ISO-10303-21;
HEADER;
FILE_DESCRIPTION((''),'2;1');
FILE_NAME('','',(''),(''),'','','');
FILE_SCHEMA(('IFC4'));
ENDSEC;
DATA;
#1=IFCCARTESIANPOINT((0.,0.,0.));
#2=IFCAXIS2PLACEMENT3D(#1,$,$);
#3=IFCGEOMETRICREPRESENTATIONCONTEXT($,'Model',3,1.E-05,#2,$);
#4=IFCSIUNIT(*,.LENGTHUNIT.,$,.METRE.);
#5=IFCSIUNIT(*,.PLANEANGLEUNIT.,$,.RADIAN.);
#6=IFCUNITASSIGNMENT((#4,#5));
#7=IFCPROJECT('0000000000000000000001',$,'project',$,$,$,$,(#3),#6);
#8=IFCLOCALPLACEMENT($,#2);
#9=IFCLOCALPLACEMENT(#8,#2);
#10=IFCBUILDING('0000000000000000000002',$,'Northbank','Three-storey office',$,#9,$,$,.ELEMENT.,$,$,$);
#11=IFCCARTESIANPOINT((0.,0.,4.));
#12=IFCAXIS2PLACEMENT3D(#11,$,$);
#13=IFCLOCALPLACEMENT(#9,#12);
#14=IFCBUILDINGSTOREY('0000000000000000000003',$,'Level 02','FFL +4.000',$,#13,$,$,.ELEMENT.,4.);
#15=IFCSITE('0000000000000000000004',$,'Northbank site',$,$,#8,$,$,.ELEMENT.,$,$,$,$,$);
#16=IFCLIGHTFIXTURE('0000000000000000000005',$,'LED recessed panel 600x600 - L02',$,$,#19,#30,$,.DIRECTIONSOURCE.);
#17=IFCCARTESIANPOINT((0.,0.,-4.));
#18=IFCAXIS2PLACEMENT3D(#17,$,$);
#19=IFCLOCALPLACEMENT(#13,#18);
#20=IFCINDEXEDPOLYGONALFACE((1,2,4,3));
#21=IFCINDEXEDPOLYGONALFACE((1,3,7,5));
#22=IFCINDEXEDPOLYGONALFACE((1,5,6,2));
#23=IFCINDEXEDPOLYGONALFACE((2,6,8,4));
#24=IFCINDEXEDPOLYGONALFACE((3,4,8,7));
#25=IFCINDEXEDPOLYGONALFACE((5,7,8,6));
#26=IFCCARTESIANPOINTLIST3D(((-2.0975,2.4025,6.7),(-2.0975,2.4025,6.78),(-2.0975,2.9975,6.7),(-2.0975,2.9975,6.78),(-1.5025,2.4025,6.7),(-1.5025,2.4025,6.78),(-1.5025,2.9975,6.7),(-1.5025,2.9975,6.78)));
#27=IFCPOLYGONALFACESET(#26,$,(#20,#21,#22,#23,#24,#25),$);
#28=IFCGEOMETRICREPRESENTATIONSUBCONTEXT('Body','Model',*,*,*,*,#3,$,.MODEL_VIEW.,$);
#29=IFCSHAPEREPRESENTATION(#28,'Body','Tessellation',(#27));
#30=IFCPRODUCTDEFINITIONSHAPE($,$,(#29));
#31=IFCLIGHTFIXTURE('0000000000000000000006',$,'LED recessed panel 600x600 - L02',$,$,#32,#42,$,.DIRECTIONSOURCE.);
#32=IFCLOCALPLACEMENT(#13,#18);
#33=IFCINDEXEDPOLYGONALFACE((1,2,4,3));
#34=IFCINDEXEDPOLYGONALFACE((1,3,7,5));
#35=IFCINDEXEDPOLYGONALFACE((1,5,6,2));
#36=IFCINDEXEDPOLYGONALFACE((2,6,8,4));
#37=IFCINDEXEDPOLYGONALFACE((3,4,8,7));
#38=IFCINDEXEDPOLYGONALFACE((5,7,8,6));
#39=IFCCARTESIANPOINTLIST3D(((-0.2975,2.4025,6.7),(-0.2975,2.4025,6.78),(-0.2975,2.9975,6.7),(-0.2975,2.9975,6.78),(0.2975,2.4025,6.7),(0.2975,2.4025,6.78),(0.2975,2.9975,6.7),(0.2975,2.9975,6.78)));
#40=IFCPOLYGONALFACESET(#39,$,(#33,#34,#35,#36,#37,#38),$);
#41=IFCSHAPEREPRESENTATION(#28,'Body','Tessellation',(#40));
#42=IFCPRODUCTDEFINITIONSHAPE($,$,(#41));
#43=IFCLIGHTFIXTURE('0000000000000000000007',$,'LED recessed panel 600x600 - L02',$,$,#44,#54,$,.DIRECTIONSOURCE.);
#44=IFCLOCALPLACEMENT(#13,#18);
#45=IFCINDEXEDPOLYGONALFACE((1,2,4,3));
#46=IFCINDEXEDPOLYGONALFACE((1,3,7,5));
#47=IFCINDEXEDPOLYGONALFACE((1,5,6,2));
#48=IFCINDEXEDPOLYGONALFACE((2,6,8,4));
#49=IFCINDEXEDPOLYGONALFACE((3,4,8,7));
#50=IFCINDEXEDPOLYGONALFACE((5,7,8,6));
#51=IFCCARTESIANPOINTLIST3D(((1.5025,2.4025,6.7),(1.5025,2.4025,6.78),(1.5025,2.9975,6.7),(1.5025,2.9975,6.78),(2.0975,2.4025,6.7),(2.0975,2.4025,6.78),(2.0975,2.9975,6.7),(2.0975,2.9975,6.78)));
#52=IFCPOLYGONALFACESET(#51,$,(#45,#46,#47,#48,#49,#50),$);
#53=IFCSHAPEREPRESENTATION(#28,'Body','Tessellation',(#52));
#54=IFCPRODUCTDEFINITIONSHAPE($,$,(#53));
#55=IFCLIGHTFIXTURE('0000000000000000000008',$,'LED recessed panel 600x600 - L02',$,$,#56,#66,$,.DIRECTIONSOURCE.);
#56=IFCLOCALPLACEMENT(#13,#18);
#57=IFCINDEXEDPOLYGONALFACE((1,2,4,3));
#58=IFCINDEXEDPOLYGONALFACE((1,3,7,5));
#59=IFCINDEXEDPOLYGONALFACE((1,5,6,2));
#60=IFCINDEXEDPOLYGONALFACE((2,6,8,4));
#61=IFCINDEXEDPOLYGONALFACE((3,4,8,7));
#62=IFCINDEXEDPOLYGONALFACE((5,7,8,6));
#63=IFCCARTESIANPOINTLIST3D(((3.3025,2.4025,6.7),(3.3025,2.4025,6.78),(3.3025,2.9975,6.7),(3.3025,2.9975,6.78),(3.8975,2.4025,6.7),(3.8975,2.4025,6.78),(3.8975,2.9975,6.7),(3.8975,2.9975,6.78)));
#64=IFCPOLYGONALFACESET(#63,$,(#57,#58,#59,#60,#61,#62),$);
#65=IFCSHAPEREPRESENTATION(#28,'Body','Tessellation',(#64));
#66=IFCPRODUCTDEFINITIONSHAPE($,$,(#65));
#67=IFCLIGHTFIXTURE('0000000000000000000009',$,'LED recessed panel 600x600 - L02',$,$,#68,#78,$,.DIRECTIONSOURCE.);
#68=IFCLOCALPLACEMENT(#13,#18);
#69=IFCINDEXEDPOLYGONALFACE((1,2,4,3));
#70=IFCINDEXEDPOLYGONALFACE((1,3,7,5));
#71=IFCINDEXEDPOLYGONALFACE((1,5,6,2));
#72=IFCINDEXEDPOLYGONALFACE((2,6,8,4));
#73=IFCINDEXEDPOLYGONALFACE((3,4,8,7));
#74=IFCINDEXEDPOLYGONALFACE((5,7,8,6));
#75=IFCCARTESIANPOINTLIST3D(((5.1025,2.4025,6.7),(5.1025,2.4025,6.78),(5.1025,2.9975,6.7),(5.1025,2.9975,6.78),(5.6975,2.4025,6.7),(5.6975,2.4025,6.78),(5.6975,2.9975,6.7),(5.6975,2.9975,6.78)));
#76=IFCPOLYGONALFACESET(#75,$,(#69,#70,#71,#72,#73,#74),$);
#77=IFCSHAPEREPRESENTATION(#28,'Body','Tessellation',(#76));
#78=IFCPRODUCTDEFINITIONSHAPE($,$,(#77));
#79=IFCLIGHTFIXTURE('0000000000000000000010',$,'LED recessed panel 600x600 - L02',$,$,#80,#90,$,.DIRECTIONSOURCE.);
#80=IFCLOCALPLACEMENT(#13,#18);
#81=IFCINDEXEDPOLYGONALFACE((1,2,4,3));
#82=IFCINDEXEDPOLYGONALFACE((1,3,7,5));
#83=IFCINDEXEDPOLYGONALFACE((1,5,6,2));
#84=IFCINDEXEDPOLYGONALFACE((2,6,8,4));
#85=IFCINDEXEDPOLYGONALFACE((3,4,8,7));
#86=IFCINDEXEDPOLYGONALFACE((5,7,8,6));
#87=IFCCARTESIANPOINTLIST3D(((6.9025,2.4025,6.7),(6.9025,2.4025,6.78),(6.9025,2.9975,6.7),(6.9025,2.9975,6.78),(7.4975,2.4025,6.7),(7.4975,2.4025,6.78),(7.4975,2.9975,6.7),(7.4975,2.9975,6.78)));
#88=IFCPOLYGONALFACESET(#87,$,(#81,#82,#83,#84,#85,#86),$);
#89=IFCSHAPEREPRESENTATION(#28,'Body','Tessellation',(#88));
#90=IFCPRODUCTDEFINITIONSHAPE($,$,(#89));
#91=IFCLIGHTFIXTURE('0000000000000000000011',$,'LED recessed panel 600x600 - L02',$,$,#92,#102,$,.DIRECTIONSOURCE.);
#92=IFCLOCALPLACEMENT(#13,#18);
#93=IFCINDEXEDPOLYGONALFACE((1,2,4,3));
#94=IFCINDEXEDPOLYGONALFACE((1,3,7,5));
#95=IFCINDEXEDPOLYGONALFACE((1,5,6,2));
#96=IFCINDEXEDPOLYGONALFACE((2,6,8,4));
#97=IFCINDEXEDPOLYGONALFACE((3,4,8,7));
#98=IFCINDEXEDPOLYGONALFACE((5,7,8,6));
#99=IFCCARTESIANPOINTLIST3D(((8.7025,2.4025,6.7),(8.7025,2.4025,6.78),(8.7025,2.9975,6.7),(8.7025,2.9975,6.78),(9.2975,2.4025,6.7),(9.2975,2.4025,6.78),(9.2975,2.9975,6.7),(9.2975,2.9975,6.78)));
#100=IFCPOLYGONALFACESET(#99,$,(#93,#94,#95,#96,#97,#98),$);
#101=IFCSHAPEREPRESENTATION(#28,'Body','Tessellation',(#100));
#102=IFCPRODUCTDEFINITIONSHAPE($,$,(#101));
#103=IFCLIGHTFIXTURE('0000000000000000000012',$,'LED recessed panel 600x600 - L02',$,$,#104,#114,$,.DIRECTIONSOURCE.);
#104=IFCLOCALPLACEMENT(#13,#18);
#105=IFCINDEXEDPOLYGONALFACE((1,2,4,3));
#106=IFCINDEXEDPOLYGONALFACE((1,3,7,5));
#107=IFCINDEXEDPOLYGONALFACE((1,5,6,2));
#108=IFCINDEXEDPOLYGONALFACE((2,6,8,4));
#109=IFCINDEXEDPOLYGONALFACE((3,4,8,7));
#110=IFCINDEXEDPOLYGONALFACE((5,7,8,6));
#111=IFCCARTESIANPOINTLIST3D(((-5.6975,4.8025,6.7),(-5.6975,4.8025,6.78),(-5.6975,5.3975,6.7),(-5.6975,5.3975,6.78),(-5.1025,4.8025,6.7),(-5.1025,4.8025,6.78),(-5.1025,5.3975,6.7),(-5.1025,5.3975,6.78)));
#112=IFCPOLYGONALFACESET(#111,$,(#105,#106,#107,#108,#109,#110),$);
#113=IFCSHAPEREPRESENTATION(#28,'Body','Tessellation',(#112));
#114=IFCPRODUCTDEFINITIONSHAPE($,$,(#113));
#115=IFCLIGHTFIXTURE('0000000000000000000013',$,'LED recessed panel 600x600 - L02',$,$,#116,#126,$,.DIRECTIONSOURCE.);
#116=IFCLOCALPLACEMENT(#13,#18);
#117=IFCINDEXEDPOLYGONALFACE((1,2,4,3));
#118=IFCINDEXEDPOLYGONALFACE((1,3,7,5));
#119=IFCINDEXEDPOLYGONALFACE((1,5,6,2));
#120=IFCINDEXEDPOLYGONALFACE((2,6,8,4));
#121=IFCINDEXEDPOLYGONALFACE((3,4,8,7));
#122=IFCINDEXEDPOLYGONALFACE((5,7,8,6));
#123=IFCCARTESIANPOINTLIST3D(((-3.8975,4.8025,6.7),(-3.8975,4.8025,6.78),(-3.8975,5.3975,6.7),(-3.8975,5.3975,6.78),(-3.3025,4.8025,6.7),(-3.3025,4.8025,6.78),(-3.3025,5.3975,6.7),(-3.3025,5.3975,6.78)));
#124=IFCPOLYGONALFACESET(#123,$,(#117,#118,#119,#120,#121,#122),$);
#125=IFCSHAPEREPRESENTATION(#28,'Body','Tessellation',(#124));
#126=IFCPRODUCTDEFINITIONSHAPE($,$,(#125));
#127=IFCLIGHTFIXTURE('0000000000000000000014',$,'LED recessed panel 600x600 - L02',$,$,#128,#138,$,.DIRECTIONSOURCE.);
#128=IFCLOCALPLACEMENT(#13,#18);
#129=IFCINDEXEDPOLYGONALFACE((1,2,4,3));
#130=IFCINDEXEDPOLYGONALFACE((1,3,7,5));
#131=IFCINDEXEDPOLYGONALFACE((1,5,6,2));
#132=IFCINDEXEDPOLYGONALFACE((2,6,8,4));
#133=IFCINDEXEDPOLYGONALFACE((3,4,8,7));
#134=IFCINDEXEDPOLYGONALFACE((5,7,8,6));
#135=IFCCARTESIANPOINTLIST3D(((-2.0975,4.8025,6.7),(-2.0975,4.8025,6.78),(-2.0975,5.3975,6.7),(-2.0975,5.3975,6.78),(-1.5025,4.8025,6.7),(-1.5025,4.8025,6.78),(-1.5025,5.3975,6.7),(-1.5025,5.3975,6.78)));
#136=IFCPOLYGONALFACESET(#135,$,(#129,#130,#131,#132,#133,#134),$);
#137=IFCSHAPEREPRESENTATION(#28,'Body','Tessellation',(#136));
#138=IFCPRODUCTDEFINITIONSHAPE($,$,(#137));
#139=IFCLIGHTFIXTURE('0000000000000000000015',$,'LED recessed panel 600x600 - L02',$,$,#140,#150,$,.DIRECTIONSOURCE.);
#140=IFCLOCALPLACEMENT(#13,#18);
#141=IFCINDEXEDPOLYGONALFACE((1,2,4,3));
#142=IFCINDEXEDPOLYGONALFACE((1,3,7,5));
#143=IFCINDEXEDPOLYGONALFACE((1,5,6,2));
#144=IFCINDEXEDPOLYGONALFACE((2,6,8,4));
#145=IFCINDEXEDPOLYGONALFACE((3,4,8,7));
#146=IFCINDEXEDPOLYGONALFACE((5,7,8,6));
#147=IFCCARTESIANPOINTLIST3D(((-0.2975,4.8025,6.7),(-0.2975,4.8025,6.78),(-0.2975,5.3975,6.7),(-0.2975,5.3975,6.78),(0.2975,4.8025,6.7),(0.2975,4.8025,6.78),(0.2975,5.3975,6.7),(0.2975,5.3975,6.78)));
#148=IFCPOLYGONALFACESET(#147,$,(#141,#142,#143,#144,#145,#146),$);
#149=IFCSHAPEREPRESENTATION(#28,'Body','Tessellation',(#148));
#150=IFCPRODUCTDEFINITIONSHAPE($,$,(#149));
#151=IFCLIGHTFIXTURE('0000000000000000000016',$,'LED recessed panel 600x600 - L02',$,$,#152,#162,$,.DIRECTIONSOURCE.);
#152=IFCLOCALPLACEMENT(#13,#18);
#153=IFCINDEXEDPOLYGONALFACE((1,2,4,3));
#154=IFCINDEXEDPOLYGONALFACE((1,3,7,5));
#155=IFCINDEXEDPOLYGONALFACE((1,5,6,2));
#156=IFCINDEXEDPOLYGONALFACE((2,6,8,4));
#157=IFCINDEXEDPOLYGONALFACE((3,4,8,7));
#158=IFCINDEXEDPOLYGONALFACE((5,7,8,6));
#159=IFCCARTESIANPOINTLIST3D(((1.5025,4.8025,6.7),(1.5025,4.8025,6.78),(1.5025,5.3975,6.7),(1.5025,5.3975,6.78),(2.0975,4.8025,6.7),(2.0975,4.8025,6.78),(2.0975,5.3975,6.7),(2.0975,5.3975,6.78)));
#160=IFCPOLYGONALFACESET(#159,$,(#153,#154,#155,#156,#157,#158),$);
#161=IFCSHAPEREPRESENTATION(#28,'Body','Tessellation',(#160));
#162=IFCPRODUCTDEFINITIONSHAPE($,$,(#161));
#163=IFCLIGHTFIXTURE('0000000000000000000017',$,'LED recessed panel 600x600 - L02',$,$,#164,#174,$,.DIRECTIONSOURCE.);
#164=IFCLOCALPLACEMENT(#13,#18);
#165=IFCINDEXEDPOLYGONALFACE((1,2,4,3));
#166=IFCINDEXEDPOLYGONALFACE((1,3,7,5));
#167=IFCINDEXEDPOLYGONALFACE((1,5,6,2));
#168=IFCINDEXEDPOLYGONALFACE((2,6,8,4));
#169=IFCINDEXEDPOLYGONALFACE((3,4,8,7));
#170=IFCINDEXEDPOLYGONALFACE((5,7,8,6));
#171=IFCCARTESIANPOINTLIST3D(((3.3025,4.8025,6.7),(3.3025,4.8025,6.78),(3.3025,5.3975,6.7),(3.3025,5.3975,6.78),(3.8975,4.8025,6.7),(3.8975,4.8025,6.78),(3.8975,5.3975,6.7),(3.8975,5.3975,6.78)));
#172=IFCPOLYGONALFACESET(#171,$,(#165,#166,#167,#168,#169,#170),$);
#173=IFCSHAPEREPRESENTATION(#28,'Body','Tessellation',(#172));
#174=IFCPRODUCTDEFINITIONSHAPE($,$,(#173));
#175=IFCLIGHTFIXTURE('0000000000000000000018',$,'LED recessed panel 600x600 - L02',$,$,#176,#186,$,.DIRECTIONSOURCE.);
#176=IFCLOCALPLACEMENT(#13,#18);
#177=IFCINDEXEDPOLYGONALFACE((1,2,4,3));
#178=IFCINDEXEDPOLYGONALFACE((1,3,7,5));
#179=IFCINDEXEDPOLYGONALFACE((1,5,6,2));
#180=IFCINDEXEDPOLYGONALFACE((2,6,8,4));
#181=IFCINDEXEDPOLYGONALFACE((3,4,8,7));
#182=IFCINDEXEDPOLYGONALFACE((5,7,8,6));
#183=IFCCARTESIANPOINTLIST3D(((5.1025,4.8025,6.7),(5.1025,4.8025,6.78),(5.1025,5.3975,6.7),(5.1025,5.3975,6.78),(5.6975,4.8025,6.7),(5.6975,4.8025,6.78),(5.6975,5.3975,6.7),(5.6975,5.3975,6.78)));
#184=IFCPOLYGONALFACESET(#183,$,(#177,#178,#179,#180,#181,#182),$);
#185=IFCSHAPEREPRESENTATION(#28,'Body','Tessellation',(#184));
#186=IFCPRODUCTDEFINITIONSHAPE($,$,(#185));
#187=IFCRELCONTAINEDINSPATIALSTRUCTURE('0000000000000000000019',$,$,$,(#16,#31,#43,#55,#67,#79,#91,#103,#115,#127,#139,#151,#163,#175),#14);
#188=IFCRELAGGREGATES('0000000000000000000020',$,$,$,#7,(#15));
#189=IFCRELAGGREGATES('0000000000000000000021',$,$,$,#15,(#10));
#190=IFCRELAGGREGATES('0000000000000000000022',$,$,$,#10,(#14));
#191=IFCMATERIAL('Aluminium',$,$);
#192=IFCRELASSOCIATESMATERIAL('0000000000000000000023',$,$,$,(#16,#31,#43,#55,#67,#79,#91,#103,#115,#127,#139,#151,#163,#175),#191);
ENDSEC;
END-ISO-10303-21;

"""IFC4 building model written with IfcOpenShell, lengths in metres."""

from ifc_helpers import new_model, si_unit, frame, origin, place, context, subcontext, project, spatial, rectangle, extrude, material, element, save


model = new_model("IFC4")

# Units and contexts
model_context = context("Model", 3, precision=1e-05, world=origin())
body_context = subcontext(model_context, "Body", "Model", "MODEL_VIEW")
ifc_project = project(units=[si_unit("LENGTHUNIT", "METRE"), si_unit("PLANEANGLEUNIT", "RADIAN")], contexts=[model_context])

# Site, building, storey
site_placement = place(None, origin())
site = spatial("IfcSite", under=ifc_project, at=site_placement, Name="Northbank site", CompositionType="ELEMENT")
building_placement = place(site_placement, origin())
building = spatial("IfcBuilding", under=site, at=building_placement, Name="Northbank", Description="Three-storey office", CompositionType="ELEMENT")
storey_placement = place(building_placement, frame((0.0, 0.0, 4.0)))
storey = spatial("IfcBuildingStorey", under=building, at=storey_placement, Name="Level 02", Description="FFL +4.000", CompositionType="ELEMENT", Elevation=4.0)

# Light fixtures
ifc_material_1 = material(Name="Aluminium")
light_fixture_1_placement = place(storey_placement, frame((0.0, 0.0, -4.0)))
element("IfcLightFixture", 1, at=light_fixture_1_placement, inside=storey, material=ifc_material_1, Name="LED recessed panel 600x600 - L02", PredefinedType="DIRECTIONSOURCE", context=body_context, shape_type="SweptSolid", body=[
    extrude(rectangle(XDim=0.595, YDim=0.595), frame((-1.8, 2.7, 6.7)), (0.0, 0.0, 1.0), 0.08),
])
light_fixture_2_placement = place(storey_placement, frame((0.0, 0.0, -4.0)))
element("IfcLightFixture", 2, at=light_fixture_2_placement, inside=storey, material=ifc_material_1, Name="LED recessed panel 600x600 - L02", PredefinedType="DIRECTIONSOURCE", context=body_context, shape_type="SweptSolid", body=[
    extrude(rectangle(XDim=0.595, YDim=0.595), frame((0.0, 2.7, 6.7)), (0.0, 0.0, 1.0), 0.08),
])
light_fixture_3_placement = place(storey_placement, frame((0.0, 0.0, -4.0)))
element("IfcLightFixture", 3, at=light_fixture_3_placement, inside=storey, material=ifc_material_1, Name="LED recessed panel 600x600 - L02", PredefinedType="DIRECTIONSOURCE", context=body_context, shape_type="SweptSolid", body=[
    extrude(rectangle(XDim=0.595, YDim=0.595), frame((1.8, 2.7, 6.7)), (0.0, 0.0, 1.0), 0.08),
])
light_fixture_4_placement = place(storey_placement, frame((0.0, 0.0, -4.0)))
element("IfcLightFixture", 4, at=light_fixture_4_placement, inside=storey, material=ifc_material_1, Name="LED recessed panel 600x600 - L02", PredefinedType="DIRECTIONSOURCE", context=body_context, shape_type="SweptSolid", body=[
    extrude(rectangle(XDim=0.595, YDim=0.595), frame((3.6, 2.7, 6.7)), (0.0, 0.0, 1.0), 0.08),
])
light_fixture_5_placement = place(storey_placement, frame((0.0, 0.0, -4.0)))
element("IfcLightFixture", 5, at=light_fixture_5_placement, inside=storey, material=ifc_material_1, Name="LED recessed panel 600x600 - L02", PredefinedType="DIRECTIONSOURCE", context=body_context, shape_type="SweptSolid", body=[
    extrude(rectangle(XDim=0.595, YDim=0.595), frame((5.4, 2.7, 6.7)), (0.0, 0.0, 1.0), 0.08),
])
light_fixture_6_placement = place(storey_placement, frame((0.0, 0.0, -4.0)))
element("IfcLightFixture", 6, at=light_fixture_6_placement, inside=storey, material=ifc_material_1, Name="LED recessed panel 600x600 - L02", PredefinedType="DIRECTIONSOURCE", context=body_context, shape_type="SweptSolid", body=[
    extrude(rectangle(XDim=0.595, YDim=0.595), frame((7.2, 2.7, 6.7)), (0.0, 0.0, 1.0), 0.08),
])
light_fixture_7_placement = place(storey_placement, frame((0.0, 0.0, -4.0)))
element("IfcLightFixture", 7, at=light_fixture_7_placement, inside=storey, material=ifc_material_1, Name="LED recessed panel 600x600 - L02", PredefinedType="DIRECTIONSOURCE", context=body_context, shape_type="SweptSolid", body=[
    extrude(rectangle(XDim=0.595, YDim=0.595), frame((9.0, 2.7, 6.7)), (0.0, 0.0, 1.0), 0.08),
])
light_fixture_8_placement = place(storey_placement, frame((0.0, 0.0, -4.0)))
element("IfcLightFixture", 8, at=light_fixture_8_placement, inside=storey, material=ifc_material_1, Name="LED recessed panel 600x600 - L02", PredefinedType="DIRECTIONSOURCE", context=body_context, shape_type="SweptSolid", body=[
    extrude(rectangle(XDim=0.595, YDim=0.595), frame((-5.4, 5.1, 6.7)), (0.0, 0.0, 1.0), 0.08),
])
light_fixture_9_placement = place(storey_placement, frame((0.0, 0.0, -4.0)))
element("IfcLightFixture", 9, at=light_fixture_9_placement, inside=storey, material=ifc_material_1, Name="LED recessed panel 600x600 - L02", PredefinedType="DIRECTIONSOURCE", context=body_context, shape_type="SweptSolid", body=[
    extrude(rectangle(XDim=0.595, YDim=0.595), frame((-3.6, 5.1, 6.7)), (0.0, 0.0, 1.0), 0.08),
])
light_fixture_10_placement = place(storey_placement, frame((0.0, 0.0, -4.0)))
element("IfcLightFixture", 10, at=light_fixture_10_placement, inside=storey, material=ifc_material_1, Name="LED recessed panel 600x600 - L02", PredefinedType="DIRECTIONSOURCE", context=body_context, shape_type="SweptSolid", body=[
    extrude(rectangle(XDim=0.595, YDim=0.595), frame((-1.8, 5.1, 6.7)), (0.0, 0.0, 1.0), 0.08),
])
light_fixture_11_placement = place(storey_placement, frame((0.0, 0.0, -4.0)))
element("IfcLightFixture", 11, at=light_fixture_11_placement, inside=storey, material=ifc_material_1, Name="LED recessed panel 600x600 - L02", PredefinedType="DIRECTIONSOURCE", context=body_context, shape_type="SweptSolid", body=[
    extrude(rectangle(XDim=0.595, YDim=0.595), frame((0.0, 5.1, 6.7)), (0.0, 0.0, 1.0), 0.08),
])
light_fixture_12_placement = place(storey_placement, frame((0.0, 0.0, -4.0)))
element("IfcLightFixture", 12, at=light_fixture_12_placement, inside=storey, material=ifc_material_1, Name="LED recessed panel 600x600 - L02", PredefinedType="DIRECTIONSOURCE", context=body_context, shape_type="SweptSolid", body=[
    extrude(rectangle(XDim=0.595, YDim=0.595), frame((1.8, 5.1, 6.7)), (0.0, 0.0, 1.0), 0.08),
])
light_fixture_13_placement = place(storey_placement, frame((0.0, 0.0, -4.0)))
element("IfcLightFixture", 13, at=light_fixture_13_placement, inside=storey, material=ifc_material_1, Name="LED recessed panel 600x600 - L02", PredefinedType="DIRECTIONSOURCE", context=body_context, shape_type="SweptSolid", body=[
    extrude(rectangle(XDim=0.595, YDim=0.595), frame((3.6, 5.1, 6.7)), (0.0, 0.0, 1.0), 0.08),
])
light_fixture_14_placement = place(storey_placement, frame((0.0, 0.0, -4.0)))
element("IfcLightFixture", 14, at=light_fixture_14_placement, inside=storey, material=ifc_material_1, Name="LED recessed panel 600x600 - L02", PredefinedType="DIRECTIONSOURCE", context=body_context, shape_type="SweptSolid", body=[
    extrude(rectangle(XDim=0.595, YDim=0.595), frame((5.4, 5.1, 6.7)), (0.0, 0.0, 1.0), 0.08),
])

save(model, "model.ifc")
